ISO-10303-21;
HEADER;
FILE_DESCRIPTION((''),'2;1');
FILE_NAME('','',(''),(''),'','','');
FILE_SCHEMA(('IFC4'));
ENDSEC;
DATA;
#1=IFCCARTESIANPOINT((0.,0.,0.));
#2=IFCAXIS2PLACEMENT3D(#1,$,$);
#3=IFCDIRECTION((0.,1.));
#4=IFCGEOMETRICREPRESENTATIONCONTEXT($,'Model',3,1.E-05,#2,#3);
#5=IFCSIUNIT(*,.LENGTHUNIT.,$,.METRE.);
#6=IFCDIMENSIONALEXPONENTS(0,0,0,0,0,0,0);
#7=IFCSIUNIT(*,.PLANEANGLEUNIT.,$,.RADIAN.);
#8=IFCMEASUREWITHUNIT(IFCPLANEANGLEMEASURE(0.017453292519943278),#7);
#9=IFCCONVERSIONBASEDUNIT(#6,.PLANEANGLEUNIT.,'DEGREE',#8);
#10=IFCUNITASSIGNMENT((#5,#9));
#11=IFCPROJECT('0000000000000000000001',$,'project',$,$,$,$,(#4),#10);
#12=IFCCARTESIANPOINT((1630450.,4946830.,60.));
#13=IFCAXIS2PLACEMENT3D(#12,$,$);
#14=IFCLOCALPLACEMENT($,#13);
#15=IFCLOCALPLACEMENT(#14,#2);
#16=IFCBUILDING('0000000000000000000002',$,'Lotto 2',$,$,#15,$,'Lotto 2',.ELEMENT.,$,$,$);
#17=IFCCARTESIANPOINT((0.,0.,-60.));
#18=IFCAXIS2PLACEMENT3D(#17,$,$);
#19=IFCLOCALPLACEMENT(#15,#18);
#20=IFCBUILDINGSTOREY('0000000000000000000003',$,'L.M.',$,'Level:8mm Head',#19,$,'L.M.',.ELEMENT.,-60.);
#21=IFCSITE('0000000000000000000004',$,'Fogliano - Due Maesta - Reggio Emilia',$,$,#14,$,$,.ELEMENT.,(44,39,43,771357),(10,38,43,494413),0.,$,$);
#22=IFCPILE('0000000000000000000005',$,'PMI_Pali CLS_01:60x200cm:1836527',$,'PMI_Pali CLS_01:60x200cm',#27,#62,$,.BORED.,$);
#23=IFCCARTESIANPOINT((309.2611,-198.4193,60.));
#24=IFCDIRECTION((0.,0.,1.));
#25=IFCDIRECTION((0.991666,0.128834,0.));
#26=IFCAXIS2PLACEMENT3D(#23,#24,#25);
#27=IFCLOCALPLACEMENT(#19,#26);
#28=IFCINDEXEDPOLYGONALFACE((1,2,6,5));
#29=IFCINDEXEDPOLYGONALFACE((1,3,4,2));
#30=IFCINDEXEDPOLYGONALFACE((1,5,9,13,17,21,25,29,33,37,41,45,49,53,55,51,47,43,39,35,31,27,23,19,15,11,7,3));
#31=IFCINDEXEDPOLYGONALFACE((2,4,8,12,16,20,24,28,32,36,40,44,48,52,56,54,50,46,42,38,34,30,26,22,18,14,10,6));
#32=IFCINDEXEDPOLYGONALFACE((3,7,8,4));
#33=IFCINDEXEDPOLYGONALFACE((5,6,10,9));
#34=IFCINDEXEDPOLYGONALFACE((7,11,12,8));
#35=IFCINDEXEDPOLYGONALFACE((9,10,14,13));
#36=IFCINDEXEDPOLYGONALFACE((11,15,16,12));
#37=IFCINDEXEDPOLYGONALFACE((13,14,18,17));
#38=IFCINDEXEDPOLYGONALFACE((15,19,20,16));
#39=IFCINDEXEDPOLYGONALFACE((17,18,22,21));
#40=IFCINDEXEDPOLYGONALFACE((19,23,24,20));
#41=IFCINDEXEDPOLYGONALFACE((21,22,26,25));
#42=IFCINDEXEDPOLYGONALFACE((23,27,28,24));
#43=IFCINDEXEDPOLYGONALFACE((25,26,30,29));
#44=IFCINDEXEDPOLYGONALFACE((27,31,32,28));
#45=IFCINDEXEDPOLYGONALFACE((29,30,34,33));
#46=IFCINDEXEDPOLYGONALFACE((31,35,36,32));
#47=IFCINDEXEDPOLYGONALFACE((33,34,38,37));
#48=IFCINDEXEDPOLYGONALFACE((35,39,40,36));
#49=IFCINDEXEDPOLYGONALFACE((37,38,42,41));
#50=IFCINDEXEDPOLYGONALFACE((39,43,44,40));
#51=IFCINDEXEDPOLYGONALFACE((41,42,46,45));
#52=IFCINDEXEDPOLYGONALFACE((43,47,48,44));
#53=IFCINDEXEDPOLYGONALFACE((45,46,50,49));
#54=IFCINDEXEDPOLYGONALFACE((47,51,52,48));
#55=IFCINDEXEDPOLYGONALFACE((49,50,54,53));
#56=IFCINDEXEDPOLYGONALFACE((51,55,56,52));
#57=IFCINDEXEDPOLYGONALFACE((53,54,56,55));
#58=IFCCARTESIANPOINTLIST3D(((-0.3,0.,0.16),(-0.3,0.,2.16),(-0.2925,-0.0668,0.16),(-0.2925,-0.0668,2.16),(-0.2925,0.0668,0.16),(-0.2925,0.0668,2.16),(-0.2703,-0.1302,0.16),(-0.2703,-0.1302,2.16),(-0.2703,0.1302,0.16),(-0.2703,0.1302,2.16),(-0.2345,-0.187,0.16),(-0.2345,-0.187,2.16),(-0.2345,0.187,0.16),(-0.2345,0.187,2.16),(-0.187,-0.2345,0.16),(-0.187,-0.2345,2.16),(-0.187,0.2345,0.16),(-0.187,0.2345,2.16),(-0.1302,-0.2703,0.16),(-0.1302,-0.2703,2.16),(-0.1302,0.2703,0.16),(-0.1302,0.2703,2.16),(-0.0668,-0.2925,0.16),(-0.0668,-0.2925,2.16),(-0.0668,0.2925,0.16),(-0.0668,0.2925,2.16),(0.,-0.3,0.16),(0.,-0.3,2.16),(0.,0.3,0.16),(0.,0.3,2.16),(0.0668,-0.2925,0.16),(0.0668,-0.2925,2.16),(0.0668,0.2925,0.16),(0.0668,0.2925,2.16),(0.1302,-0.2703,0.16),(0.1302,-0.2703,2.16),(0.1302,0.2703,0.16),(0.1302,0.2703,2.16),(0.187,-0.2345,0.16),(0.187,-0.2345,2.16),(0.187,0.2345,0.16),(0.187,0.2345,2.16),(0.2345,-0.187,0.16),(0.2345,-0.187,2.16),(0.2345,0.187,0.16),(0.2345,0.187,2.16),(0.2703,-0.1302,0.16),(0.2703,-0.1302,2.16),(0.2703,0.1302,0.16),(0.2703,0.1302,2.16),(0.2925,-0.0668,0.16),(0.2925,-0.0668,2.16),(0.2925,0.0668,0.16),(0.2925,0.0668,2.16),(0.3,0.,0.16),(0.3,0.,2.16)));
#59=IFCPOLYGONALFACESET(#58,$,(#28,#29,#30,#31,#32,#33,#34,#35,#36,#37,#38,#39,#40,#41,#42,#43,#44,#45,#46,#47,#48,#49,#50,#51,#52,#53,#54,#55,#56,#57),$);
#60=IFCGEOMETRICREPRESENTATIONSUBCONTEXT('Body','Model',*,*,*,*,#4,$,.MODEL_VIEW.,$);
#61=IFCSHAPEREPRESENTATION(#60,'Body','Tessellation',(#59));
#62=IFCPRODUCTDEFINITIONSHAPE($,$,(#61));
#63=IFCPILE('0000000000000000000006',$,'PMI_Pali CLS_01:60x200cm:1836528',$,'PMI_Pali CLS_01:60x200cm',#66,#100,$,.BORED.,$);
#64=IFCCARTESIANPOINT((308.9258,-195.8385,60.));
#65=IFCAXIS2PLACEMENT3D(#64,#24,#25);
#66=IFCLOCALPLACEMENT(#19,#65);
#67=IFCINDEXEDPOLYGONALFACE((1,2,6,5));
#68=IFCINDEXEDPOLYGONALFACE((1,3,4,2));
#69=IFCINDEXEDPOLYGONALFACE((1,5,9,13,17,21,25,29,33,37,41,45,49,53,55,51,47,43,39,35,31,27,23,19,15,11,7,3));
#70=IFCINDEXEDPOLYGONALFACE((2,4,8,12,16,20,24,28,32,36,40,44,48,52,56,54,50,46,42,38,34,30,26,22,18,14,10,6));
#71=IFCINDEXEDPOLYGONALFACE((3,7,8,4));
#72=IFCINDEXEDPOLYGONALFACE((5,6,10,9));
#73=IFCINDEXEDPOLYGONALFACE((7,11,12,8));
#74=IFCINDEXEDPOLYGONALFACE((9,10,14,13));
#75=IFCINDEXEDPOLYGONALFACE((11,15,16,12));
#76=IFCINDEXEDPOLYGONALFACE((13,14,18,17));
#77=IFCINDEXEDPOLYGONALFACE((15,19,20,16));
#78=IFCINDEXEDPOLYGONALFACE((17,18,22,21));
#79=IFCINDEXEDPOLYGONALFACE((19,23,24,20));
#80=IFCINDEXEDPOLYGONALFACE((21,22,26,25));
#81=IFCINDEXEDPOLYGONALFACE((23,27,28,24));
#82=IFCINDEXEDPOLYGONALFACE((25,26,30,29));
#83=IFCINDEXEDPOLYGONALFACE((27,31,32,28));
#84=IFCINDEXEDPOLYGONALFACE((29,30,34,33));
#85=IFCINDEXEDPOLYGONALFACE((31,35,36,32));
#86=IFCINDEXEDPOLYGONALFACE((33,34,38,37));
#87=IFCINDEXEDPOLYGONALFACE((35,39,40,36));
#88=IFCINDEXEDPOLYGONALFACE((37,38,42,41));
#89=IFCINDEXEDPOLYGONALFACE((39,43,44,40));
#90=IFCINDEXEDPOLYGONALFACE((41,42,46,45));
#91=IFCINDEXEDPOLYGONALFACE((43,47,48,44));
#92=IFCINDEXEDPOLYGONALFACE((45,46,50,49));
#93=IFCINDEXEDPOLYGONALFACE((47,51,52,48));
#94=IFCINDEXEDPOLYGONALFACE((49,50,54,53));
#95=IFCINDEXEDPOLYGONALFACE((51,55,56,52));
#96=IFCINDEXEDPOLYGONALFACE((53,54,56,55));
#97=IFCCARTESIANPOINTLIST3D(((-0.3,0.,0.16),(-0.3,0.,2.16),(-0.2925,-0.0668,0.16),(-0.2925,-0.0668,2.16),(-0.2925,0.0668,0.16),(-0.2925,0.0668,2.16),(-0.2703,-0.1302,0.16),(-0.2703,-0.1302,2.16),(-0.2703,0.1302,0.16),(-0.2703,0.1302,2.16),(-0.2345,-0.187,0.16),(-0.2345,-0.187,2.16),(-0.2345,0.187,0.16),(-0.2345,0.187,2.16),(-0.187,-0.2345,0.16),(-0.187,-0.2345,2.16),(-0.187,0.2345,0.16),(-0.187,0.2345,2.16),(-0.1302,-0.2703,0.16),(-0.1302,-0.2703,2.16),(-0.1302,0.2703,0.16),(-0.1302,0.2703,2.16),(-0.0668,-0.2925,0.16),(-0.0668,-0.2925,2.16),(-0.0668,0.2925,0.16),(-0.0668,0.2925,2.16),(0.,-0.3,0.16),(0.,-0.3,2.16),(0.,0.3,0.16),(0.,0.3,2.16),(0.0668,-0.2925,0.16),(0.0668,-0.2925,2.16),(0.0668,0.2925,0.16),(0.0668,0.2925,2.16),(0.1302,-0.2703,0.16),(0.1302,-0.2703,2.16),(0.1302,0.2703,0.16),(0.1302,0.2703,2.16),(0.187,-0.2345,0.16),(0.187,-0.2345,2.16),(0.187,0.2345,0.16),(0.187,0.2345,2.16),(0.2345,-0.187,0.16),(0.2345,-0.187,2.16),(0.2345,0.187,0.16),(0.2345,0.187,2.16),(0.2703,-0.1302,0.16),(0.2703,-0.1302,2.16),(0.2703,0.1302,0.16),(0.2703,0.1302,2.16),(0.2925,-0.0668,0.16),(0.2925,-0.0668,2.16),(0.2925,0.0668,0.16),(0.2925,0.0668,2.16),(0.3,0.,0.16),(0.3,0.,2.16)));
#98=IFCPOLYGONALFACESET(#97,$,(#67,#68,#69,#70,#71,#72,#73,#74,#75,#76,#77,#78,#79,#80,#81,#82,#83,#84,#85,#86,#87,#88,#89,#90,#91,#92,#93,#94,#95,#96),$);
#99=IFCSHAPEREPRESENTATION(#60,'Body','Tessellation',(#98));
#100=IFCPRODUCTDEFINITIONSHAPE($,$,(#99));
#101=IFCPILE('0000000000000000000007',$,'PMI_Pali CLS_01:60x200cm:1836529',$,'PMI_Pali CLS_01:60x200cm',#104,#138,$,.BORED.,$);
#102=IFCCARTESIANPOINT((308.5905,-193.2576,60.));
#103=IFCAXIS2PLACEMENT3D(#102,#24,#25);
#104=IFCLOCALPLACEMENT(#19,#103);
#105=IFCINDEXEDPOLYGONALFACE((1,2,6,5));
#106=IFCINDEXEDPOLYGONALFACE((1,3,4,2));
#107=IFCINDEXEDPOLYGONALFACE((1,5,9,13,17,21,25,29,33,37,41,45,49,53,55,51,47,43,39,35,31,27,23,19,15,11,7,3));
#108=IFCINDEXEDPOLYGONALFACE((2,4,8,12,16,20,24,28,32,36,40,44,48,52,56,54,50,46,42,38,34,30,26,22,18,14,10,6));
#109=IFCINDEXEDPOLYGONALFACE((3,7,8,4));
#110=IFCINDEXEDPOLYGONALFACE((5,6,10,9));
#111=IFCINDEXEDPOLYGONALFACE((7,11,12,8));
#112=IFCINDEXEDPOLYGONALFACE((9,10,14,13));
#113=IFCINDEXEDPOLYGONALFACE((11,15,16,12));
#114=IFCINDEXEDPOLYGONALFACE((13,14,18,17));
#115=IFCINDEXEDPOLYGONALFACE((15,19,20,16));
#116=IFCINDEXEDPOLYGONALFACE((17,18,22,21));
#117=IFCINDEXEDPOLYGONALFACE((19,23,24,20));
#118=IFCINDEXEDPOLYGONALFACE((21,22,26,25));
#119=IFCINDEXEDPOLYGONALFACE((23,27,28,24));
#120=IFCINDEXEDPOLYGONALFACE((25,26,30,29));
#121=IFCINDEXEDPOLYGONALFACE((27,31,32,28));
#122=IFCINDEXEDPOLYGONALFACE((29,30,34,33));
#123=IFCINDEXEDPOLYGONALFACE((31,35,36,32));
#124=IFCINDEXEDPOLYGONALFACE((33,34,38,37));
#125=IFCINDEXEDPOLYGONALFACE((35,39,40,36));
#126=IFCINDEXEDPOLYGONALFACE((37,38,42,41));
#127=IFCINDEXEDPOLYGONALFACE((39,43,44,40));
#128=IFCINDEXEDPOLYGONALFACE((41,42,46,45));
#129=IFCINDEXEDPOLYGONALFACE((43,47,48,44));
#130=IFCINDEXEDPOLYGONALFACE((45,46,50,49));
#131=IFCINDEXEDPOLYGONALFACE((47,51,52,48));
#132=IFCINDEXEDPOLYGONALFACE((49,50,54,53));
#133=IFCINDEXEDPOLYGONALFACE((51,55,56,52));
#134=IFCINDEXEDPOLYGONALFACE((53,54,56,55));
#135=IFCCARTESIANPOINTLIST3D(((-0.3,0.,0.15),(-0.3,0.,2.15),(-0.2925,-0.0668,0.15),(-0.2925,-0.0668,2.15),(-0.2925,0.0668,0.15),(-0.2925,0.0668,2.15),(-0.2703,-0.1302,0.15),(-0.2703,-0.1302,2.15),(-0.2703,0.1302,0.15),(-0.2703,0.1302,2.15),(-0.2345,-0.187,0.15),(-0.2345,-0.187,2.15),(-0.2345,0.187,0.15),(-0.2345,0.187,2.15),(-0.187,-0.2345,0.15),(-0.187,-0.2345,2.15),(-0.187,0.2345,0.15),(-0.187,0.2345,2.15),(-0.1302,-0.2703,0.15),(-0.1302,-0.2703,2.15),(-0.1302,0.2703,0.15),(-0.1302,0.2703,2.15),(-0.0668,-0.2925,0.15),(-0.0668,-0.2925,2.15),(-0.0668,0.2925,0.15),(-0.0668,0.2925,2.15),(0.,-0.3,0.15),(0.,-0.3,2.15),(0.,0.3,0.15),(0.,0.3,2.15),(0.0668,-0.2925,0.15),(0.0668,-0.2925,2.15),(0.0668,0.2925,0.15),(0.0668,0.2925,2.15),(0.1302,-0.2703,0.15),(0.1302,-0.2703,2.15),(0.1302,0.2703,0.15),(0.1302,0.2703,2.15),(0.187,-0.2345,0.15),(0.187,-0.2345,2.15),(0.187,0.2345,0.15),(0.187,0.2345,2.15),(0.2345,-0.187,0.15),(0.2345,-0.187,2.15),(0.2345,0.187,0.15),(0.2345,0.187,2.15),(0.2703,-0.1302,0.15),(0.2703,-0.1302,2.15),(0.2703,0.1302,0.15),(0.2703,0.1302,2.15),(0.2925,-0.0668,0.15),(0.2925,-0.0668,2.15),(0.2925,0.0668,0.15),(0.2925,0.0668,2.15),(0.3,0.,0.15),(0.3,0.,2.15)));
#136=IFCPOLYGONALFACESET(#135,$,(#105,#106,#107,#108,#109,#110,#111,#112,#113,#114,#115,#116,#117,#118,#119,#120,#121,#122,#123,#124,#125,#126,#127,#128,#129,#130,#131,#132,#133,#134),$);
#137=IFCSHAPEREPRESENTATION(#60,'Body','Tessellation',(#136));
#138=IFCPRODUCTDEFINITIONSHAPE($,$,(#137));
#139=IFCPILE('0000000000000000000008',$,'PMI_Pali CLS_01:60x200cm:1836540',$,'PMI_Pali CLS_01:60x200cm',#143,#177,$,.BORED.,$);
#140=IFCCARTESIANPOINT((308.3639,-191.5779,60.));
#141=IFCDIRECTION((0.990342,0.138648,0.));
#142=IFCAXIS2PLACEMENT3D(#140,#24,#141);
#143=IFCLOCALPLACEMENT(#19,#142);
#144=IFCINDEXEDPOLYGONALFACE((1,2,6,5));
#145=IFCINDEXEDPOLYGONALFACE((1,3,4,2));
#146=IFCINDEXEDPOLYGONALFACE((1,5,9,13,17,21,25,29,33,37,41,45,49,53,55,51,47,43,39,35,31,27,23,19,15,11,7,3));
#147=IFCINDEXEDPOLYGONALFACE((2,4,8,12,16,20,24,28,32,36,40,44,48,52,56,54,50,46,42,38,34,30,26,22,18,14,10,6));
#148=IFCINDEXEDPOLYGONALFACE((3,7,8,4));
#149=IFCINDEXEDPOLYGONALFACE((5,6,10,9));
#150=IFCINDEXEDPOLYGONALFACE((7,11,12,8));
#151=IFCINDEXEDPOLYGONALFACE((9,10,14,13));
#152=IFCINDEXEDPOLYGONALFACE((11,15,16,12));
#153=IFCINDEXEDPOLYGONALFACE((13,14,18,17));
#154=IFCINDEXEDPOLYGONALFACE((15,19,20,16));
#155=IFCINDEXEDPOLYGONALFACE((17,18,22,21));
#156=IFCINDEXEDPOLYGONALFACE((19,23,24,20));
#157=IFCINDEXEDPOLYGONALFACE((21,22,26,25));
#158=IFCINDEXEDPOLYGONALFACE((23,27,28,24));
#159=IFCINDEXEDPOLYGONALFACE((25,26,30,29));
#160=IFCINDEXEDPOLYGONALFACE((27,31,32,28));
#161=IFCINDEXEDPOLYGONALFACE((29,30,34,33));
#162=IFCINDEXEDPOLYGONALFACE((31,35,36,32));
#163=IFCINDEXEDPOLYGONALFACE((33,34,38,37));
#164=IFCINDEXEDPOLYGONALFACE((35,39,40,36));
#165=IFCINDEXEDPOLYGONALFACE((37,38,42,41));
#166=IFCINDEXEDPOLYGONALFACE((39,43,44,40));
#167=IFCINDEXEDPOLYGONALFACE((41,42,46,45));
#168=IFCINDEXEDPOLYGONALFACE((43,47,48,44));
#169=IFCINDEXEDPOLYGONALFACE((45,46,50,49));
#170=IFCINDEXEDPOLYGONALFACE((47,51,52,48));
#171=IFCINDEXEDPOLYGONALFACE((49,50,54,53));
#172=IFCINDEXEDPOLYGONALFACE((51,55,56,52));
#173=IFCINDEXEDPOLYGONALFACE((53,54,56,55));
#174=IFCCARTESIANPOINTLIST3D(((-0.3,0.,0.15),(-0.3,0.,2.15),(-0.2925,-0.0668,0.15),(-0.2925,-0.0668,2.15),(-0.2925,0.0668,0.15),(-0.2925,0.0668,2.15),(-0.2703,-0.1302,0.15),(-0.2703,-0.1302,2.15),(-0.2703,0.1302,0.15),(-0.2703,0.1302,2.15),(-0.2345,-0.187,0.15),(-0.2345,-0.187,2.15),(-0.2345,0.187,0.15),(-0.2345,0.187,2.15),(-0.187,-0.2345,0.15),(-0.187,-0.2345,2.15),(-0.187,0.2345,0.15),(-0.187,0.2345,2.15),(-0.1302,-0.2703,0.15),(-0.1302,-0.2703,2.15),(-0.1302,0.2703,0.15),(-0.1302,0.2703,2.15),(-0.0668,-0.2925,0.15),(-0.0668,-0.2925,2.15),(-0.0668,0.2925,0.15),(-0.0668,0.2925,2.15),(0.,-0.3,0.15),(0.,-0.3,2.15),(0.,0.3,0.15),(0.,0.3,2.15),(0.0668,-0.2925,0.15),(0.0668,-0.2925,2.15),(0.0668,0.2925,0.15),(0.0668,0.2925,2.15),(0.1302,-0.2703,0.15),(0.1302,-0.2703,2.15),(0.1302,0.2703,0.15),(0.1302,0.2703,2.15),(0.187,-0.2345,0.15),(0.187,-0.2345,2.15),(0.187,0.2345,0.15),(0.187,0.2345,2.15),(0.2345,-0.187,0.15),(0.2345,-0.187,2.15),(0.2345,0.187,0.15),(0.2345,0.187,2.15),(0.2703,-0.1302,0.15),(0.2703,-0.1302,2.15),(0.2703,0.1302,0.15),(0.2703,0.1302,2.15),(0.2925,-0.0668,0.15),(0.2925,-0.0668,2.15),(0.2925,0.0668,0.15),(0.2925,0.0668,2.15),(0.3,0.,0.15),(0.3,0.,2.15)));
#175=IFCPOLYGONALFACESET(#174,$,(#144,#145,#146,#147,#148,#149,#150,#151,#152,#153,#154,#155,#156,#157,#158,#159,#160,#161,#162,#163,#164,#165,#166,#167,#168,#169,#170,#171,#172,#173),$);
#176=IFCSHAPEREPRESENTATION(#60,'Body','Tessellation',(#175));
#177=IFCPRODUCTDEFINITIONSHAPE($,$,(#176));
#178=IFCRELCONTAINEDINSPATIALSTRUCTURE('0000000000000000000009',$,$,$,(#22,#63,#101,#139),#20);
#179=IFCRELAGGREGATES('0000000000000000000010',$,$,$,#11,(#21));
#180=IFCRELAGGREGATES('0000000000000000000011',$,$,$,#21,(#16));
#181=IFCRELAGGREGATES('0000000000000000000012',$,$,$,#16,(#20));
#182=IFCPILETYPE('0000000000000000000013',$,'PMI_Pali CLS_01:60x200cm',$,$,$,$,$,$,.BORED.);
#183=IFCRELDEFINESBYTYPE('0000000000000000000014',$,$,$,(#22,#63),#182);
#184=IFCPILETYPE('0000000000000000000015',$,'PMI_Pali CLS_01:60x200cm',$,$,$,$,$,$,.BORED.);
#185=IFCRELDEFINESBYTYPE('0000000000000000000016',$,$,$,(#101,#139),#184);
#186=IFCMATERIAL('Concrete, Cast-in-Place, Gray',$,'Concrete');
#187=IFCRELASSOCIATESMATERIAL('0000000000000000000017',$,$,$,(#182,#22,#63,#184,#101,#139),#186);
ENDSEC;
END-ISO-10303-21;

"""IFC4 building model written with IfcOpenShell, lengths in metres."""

from ifc_helpers import new_model, entity, si_unit, converted_unit, direction, frame, origin, place, context, subcontext, project, spatial, arc, indexed_curve, outline, extrude, source, transform, mapped, material, type_object, type_shapes, element, save


model = new_model("IFC4")

# Units and contexts
model_context = context("Model", 3, precision=1e-05, world=origin(), true_north=direction((0.0, 1.0)))
body_context = subcontext(model_context, "Body", "Model", "MODEL_VIEW")
ifc_project = project(units=[si_unit("LENGTHUNIT", "METRE"), converted_unit("PLANEANGLEUNIT", "DEGREE", entity("IfcPlaneAngleMeasure", 0.017453292519943278), si_unit("PLANEANGLEUNIT", "RADIAN"), dimensions=[0, 0, 0, 0, 0, 0, 0])], contexts=[model_context])

# Site, building, storey
site_placement = place(None, frame((1630450.0, 4946830.0, 60.0)))
site = spatial("IfcSite", under=ifc_project, at=site_placement, Name="Fogliano - Due Maesta - Reggio Emilia", CompositionType="ELEMENT", RefLatitude=(44, 39, 43, 771357), RefLongitude=(10, 38, 43, 494413), RefElevation=0.0)
building_placement = place(site_placement, origin())
building = spatial("IfcBuilding", under=site, at=building_placement, Name="Lotto 2", LongName="Lotto 2", CompositionType="ELEMENT")
storey_placement = place(building_placement, frame((0.0, 0.0, -60.0)))
storey = spatial("IfcBuildingStorey", under=building, at=storey_placement, Name="L.M.", ObjectType="Level:8mm Head", LongName="L.M.", CompositionType="ELEMENT", Elevation=-60.0)

# Piles
ifc_material_1 = material(Name="Concrete, Cast-in-Place, Gray", Category="Concrete")
pile_type_1 = type_object("IfcPileType", Name="PMI_Pali CLS_01:60x200cm", PredefinedType="BORED", material=ifc_material_1)
shared_shape_1 = source(origin(), body_context, "Body", "SweptSolid", [
    extrude(outline(indexed_curve([(-0.3, 0.0), (0.0, -0.3), (0.3, 0.0), (0.0, 0.3)], segments=[arc(1, 2, 3), arc(3, 4, 1)], self_intersect=False)), frame((0.0, 0.0, 0.16)), (0.0, 0.0, 1.0), 2.0),
])
type_shapes(pile_type_1, [shared_shape_1])
for number, where, z_axis, x_axis, name in (
    (1, (309.2611, -198.4193, 60.0), (0.0, 0.0, 1.0), (0.991666, 0.128834, 0.0), "PMI_Pali CLS_01:60x200cm:1836527"),
    (2, (308.9258, -195.8385, 60.0), (0.0, 0.0, 1.0), (0.991666, 0.128834, 0.0), "PMI_Pali CLS_01:60x200cm:1836528"),
):
    element("IfcPile", number, at=place(storey_placement, frame(where, z_axis=z_axis, x_axis=x_axis)), inside=storey, type_object=pile_type_1, material=ifc_material_1, Name=name, ObjectType="PMI_Pali CLS_01:60x200cm", PredefinedType="BORED", context=body_context, shape_type="MappedRepresentation", body=[
        mapped(shared_shape_1, transform((0.0, 0.0, 0.0), scale=1.0)),
    ])
pile_type_2 = type_object("IfcPileType", Name="PMI_Pali CLS_01:60x200cm", PredefinedType="BORED", material=ifc_material_1)
shared_shape_2 = source(origin(), body_context, "Body", "SweptSolid", [
    extrude(outline(indexed_curve([(-0.3, 0.0), (0.0, -0.3), (0.3, 0.0), (0.0, 0.3)], segments=[arc(1, 2, 3), arc(3, 4, 1)], self_intersect=False)), frame((0.0, 0.0, 0.15)), (0.0, 0.0, 1.0), 2.0),
])
type_shapes(pile_type_2, [shared_shape_2])
for number, where, z_axis, x_axis, name in (
    (3, (308.5905, -193.2576, 60.0), (0.0, 0.0, 1.0), (0.991666, 0.128834, 0.0), "PMI_Pali CLS_01:60x200cm:1836529"),
    (4, (308.3639, -191.5779, 60.0), (0.0, 0.0, 1.0), (0.990342, 0.138648, 0.0), "PMI_Pali CLS_01:60x200cm:1836540"),
):
    element("IfcPile", number, at=place(storey_placement, frame(where, z_axis=z_axis, x_axis=x_axis)), inside=storey, type_object=pile_type_2, material=ifc_material_1, Name=name, ObjectType="PMI_Pali CLS_01:60x200cm", PredefinedType="BORED", context=body_context, shape_type="MappedRepresentation", body=[
        mapped(shared_shape_2, transform((0.0, 0.0, 0.0), scale=1.0)),
    ])

save(model, "model.ifc")
